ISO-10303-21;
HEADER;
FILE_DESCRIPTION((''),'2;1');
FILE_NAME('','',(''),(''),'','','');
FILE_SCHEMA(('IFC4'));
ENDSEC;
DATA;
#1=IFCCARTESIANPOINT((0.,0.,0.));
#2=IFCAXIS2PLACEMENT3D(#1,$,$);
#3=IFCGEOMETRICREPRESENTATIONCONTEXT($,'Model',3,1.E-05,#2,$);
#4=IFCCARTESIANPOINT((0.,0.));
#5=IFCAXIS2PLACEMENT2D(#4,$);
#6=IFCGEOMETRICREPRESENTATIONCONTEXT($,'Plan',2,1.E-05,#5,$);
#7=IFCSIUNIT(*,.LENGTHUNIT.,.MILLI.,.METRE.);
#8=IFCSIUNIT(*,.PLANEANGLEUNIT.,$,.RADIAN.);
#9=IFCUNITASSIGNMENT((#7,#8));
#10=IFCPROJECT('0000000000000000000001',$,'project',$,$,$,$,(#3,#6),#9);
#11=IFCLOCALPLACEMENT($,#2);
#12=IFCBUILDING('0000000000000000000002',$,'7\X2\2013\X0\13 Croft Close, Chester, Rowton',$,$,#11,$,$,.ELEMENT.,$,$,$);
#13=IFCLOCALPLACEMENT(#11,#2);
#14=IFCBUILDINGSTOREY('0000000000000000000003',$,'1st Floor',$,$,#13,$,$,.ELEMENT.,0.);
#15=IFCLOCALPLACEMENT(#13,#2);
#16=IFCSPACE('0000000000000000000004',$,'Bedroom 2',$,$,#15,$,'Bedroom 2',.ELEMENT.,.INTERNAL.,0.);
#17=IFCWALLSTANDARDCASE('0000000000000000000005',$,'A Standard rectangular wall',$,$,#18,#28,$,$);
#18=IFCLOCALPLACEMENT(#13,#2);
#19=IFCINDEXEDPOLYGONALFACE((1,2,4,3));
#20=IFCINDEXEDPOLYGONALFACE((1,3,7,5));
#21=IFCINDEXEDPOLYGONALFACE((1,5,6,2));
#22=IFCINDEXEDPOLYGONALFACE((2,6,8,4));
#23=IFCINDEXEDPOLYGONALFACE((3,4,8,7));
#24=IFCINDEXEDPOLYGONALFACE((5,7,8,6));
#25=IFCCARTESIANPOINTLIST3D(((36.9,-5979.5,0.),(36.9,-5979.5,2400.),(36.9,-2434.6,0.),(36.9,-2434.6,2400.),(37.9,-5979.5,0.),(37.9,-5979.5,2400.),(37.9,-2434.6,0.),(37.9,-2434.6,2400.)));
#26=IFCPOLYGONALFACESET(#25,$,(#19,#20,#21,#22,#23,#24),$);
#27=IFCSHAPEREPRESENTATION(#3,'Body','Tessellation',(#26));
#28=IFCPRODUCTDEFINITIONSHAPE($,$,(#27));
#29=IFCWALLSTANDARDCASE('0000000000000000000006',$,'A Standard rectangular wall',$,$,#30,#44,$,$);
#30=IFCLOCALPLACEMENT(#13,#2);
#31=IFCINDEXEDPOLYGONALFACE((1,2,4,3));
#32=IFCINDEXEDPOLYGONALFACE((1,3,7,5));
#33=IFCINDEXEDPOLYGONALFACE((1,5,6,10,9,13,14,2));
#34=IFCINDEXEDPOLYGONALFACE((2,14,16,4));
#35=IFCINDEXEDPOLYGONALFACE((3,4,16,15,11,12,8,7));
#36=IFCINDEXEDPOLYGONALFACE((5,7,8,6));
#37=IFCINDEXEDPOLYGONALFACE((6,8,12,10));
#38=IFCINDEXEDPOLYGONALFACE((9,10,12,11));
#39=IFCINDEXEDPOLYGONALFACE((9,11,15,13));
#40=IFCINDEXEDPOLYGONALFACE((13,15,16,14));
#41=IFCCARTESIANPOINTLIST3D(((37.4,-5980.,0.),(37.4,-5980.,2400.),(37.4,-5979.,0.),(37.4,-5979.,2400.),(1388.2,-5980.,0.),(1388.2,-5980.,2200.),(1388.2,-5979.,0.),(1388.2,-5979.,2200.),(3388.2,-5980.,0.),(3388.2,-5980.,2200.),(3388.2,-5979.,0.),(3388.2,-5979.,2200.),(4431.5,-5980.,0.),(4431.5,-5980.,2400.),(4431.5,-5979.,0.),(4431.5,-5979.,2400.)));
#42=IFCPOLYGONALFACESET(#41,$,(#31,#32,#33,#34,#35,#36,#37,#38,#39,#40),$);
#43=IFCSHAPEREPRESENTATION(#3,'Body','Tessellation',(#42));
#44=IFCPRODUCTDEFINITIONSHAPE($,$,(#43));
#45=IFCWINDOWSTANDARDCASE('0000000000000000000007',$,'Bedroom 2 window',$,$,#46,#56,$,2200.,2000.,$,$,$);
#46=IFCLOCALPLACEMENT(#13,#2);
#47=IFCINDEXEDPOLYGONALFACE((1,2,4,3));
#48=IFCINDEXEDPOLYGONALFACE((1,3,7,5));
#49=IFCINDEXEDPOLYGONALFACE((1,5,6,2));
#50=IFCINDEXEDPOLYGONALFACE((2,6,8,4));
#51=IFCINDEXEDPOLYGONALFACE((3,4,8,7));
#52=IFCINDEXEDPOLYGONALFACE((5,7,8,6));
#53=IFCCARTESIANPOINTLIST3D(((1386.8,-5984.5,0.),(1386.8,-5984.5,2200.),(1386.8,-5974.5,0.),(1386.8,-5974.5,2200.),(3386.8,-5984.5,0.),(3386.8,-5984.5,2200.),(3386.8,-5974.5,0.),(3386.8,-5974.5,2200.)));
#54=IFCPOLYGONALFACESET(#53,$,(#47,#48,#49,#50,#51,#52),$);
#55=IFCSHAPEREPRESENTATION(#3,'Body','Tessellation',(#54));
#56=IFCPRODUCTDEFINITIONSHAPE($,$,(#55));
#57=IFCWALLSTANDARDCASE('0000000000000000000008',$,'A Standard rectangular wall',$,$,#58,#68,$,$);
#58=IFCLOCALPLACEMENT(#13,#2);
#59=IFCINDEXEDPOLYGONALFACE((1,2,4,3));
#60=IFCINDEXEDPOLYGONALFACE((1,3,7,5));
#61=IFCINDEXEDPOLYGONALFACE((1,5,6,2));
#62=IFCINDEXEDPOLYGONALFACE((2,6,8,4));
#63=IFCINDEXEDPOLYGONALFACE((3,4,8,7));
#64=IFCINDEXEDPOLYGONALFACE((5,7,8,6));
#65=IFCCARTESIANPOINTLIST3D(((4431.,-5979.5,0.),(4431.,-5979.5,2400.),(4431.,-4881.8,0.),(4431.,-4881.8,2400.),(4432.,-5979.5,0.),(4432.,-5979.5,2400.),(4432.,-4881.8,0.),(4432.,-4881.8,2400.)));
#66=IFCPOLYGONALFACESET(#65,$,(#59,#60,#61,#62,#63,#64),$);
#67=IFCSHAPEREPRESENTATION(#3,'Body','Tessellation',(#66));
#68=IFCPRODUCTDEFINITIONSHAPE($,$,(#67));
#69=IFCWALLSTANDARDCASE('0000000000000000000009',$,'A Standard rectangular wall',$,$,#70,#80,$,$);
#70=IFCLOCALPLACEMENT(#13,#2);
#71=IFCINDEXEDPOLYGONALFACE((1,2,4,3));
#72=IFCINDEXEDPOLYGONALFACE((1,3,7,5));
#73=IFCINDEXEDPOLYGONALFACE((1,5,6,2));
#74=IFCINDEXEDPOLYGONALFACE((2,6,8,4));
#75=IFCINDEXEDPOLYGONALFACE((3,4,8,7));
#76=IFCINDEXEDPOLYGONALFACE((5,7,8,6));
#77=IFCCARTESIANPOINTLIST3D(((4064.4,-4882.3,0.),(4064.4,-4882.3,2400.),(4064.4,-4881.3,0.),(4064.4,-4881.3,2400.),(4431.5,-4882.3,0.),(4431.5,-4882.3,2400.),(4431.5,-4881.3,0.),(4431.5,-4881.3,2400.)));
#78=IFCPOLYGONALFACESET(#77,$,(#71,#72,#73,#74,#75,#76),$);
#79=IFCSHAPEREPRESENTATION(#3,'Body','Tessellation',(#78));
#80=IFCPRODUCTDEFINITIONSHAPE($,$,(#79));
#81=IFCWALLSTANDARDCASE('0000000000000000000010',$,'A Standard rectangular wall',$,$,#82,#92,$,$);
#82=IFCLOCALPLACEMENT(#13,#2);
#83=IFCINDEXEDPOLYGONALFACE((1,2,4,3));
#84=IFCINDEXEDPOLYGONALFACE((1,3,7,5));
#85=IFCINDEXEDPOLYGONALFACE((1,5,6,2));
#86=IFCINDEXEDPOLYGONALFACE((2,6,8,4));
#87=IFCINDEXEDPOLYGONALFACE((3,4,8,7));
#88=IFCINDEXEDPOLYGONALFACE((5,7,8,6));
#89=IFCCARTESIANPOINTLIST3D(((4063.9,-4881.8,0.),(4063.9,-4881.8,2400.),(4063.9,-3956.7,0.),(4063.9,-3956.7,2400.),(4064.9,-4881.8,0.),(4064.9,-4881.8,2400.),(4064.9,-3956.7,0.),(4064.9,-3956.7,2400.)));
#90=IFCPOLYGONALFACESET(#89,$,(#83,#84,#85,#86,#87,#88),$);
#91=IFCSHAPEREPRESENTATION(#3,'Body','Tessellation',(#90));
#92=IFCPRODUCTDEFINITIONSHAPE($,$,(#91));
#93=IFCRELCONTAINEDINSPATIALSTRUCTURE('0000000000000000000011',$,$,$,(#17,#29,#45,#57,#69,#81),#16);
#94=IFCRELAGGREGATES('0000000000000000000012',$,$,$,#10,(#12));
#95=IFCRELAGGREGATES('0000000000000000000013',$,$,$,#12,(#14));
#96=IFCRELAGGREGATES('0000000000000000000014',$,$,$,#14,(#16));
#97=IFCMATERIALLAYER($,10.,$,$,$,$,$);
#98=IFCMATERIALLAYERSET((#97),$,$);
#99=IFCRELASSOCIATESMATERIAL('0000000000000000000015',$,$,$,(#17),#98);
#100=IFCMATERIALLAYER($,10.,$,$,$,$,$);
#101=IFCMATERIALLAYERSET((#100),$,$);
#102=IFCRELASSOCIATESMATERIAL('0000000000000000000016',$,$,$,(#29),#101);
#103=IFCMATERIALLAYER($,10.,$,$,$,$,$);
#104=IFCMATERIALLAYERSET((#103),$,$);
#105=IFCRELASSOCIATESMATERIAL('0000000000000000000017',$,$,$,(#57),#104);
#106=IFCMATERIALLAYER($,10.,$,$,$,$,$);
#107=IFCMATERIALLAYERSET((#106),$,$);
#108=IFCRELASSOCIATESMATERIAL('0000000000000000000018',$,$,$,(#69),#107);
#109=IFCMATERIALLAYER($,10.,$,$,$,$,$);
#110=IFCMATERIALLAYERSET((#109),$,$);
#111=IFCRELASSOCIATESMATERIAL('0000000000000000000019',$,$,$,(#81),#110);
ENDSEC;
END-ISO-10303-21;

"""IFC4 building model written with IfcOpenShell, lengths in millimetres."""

from ifc_helpers import new_model, si_unit, frame, origin, origin_2d, place, context, project, spatial, rectangle, extrude, layer, layer_set, layer_usage, element, fill, save


model = new_model("IFC4")

# Units and contexts
model_context = context("Model", 3, precision=1e-05, world=origin())
plan_context = context("Plan", 2, precision=1e-05, world=origin_2d())
ifc_project = project(units=[si_unit("LENGTHUNIT", "METRE", prefix="MILLI"), si_unit("PLANEANGLEUNIT", "RADIAN")], contexts=[model_context, plan_context])

# Building, storey
building_placement = place(None, origin())
building = spatial("IfcBuilding", under=ifc_project, at=building_placement, Name="7–13 Croft Close, Chester, Rowton", CompositionType="ELEMENT")
storey_placement = place(building_placement, origin())
storey = spatial("IfcBuildingStorey", under=building, at=storey_placement, Name="1st Floor", CompositionType="ELEMENT", Elevation=0.0)

# Shared definitions
space_1_placement = place(storey_placement, origin())
space_1 = spatial("IfcSpace", under=storey, at=space_1_placement, Name="Bedroom 2", LongName="Bedroom 2", CompositionType="ELEMENT", PredefinedType="INTERNAL", ElevationWithFlooring=0.0)

# Wall
ifc_layer_1 = layer(None, 10.0)
ifc_layer_set_1 = layer_set([ifc_layer_1])
ifc_layer_usage_1 = layer_usage(ifc_layer_set_1, "AXIS2", "NEGATIVE", 150.0)
wall_1_placement = place(storey_placement, origin())
element("IfcWallStandardCase", 1, at=wall_1_placement, inside=space_1, material=ifc_layer_usage_1, Name="A Standard rectangular wall", context=model_context, shape_type="SweptSolid", body=[
    extrude(rectangle(XDim=1.0, YDim=3544.9, at=origin_2d()), frame((37.4, -4207.0, 0.0), x_axis=(1.0, 0.0, 0.0)), (0.0, 0.0, 1.0), 2400.0),
])

# Wall, opening, window
ifc_layer_2 = layer(None, 10.0)
ifc_layer_set_2 = layer_set([ifc_layer_2])
ifc_layer_usage_2 = layer_usage(ifc_layer_set_2, "AXIS2", "NEGATIVE", 150.0)
wall_2_placement = place(storey_placement, origin())
wall_2 = element("IfcWallStandardCase", 2, at=wall_2_placement, inside=space_1, material=ifc_layer_usage_2, Name="A Standard rectangular wall", context=model_context, shape_type="SweptSolid", body=[
    extrude(rectangle(XDim=1.0, YDim=4394.1, at=origin_2d()), frame((2234.4, -5979.5, 0.0), x_axis=(0.0, 1.0, 0.0)), (0.0, 0.0, 1.0), 2400.0),
])
opening_1_placement = place(storey_placement, origin())
opening_1 = element("IfcOpeningElement", 3, at=opening_1_placement, cuts=wall_2, context=model_context, shape_type="SweptSolid", body=[
    extrude(rectangle(XDim=10.0, YDim=2000.0, at=origin_2d()), frame((2388.2, -5979.5, 0.0), x_axis=(0.0, 1.0, 0.0)), (0.0, 0.0, 1.0), 2200.0),
])
window_1_placement = place(storey_placement, frame((-1.4, 0.0, 0.0)))
window_1 = element("IfcWindowStandardCase", 4, at=window_1_placement, inside=space_1, Name="Bedroom 2 window", OverallHeight=2200.0, OverallWidth=2000.0, context=model_context, shape_type="SweptSolid", body=[
    extrude(rectangle(XDim=10.0, YDim=2000.0, at=origin_2d()), frame((2388.2, -5979.5, 0.0), x_axis=(0.0, 1.0, 0.0)), (0.0, 0.0, 1.0), 2200.0),
])
fill(opening_1, window_1)

# Walls
ifc_layer_3 = layer(None, 10.0)
ifc_layer_set_3 = layer_set([ifc_layer_3])
ifc_layer_usage_3 = layer_usage(ifc_layer_set_3, "AXIS2", "NEGATIVE", 150.0)
wall_3_placement = place(storey_placement, origin())
element("IfcWallStandardCase", 5, at=wall_3_placement, inside=space_1, material=ifc_layer_usage_3, Name="A Standard rectangular wall", context=model_context, shape_type="SweptSolid", body=[
    extrude(rectangle(XDim=1.0, YDim=1097.7, at=origin_2d()), frame((4431.5, -5430.7, 0.0), x_axis=(-1.0, 0.0, 0.0)), (0.0, 0.0, 1.0), 2400.0),
])
ifc_layer_4 = layer(None, 10.0)
ifc_layer_set_4 = layer_set([ifc_layer_4])
ifc_layer_usage_4 = layer_usage(ifc_layer_set_4, "AXIS2", "NEGATIVE", 150.0)
wall_4_placement = place(storey_placement, origin())
element("IfcWallStandardCase", 6, at=wall_4_placement, inside=space_1, material=ifc_layer_usage_4, Name="A Standard rectangular wall", context=model_context, shape_type="SweptSolid", body=[
    extrude(rectangle(XDim=1.0, YDim=367.1, at=origin_2d()), frame((4248.0, -4881.8, 0.0), x_axis=(0.0, -1.0, 0.0)), (0.0, 0.0, 1.0), 2400.0),
])
ifc_layer_5 = layer(None, 10.0)
ifc_layer_set_5 = layer_set([ifc_layer_5])
ifc_layer_usage_5 = layer_usage(ifc_layer_set_5, "AXIS2", "NEGATIVE", 150.0)
wall_5_placement = place(storey_placement, origin())
element("IfcWallStandardCase", 7, at=wall_5_placement, inside=space_1, material=ifc_layer_usage_5, Name="A Standard rectangular wall", context=model_context, shape_type="SweptSolid", body=[
    extrude(rectangle(XDim=1.0, YDim=925.1, at=origin_2d()), frame((4064.4, -4419.2, 0.0), x_axis=(-1.0, 0.0, 0.0)), (0.0, 0.0, 1.0), 2400.0),
])

save(model, "model.ifc")
